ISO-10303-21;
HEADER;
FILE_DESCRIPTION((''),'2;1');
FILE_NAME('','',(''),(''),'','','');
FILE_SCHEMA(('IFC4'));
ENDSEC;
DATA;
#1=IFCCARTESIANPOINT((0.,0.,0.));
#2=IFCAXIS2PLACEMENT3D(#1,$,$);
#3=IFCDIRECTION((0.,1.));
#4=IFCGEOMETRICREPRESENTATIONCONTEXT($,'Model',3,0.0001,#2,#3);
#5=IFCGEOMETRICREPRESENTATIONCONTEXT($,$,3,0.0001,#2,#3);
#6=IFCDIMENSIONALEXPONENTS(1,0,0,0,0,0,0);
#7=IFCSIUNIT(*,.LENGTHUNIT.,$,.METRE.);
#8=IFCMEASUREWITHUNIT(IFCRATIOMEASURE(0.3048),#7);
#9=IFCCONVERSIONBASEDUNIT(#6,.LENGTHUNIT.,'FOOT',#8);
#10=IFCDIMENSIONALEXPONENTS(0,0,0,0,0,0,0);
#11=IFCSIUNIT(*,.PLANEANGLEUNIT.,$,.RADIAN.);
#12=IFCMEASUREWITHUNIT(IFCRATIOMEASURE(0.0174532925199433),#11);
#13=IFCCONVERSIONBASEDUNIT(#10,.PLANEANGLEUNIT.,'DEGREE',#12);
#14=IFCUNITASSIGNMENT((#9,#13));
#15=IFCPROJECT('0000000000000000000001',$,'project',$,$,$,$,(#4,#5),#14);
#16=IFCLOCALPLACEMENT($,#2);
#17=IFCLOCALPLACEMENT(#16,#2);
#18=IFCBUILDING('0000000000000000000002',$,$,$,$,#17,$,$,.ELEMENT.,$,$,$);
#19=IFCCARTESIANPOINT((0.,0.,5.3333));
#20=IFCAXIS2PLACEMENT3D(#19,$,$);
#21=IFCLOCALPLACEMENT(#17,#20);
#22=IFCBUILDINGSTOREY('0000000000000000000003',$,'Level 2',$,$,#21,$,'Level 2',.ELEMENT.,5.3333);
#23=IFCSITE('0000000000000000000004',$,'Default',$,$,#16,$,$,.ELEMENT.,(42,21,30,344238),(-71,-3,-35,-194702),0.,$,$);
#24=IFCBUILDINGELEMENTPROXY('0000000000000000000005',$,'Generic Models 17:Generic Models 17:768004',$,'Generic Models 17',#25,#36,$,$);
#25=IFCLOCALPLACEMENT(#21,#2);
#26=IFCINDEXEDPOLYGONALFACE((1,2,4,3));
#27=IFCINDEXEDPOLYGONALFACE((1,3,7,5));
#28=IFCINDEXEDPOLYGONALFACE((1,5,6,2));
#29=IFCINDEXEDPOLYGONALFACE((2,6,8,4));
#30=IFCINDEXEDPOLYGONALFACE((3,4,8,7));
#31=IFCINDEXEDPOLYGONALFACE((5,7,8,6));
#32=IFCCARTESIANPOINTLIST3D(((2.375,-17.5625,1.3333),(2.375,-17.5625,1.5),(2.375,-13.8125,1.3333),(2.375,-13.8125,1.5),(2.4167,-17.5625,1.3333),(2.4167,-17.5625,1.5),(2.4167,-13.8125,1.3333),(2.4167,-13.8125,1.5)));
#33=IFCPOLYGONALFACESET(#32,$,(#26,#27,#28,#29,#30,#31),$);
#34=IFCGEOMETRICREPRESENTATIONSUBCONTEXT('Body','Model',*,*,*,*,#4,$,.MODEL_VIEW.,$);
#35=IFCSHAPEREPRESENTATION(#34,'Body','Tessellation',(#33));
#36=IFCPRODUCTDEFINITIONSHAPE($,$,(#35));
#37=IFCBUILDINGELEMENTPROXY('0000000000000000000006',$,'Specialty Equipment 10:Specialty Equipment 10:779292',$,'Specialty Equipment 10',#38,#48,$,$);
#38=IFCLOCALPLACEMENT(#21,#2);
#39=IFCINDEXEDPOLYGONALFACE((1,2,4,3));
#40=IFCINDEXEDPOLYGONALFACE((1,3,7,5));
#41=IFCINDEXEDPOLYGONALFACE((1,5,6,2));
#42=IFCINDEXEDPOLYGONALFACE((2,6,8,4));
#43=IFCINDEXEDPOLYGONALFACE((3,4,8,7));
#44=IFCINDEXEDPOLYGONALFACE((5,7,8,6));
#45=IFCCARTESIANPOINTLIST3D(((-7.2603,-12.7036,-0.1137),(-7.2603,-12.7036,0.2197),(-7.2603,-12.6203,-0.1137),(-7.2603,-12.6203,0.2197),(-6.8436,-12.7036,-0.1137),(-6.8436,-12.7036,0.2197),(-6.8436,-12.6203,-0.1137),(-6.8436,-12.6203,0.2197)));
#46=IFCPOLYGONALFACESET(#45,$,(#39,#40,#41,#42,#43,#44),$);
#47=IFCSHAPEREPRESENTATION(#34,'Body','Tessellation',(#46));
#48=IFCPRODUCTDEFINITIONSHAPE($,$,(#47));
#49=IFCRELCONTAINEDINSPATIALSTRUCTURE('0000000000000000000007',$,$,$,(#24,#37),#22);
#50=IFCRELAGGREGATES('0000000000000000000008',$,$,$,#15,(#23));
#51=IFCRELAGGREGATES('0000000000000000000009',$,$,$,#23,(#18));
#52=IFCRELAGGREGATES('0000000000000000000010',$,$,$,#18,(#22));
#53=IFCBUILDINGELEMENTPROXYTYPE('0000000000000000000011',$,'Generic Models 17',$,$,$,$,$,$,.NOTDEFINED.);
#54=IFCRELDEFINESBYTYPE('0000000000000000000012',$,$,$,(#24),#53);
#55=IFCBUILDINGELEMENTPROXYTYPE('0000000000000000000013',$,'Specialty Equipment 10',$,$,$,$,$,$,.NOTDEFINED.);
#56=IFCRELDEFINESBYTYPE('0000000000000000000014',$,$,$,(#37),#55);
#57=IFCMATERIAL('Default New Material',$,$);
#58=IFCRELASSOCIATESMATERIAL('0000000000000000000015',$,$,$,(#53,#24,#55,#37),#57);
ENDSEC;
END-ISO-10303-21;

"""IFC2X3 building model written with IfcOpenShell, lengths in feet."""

from ifc_helpers import new_model, entity, si_unit, converted_unit, direction, frame, frame_2d, origin, origin_2d_with_axis, place, context, subcontext, project, spatial, rectangle, extrude, source, transform, mapped, material, type_object, type_shapes, element, save


model = new_model("IFC2X3")

# Units and contexts
model_context = context("Model", 3, precision=0.0001, world=origin(), true_north=direction((0.0, 1.0)))
context_of_model = context(None, 3, precision=0.0001, world=origin(), true_north=direction((0.0, 1.0)))
body_context = subcontext(model_context, "Body", "Model", "MODEL_VIEW")
ifc_project = project(units=[converted_unit("LENGTHUNIT", "FOOT", entity("IfcRatioMeasure", 0.3048), si_unit("LENGTHUNIT", "METRE"), dimensions=[1, 0, 0, 0, 0, 0, 0]), converted_unit("PLANEANGLEUNIT", "DEGREE", entity("IfcRatioMeasure", 0.0174532925199433), si_unit("PLANEANGLEUNIT", "RADIAN"), dimensions=[0, 0, 0, 0, 0, 0, 0])], contexts=[model_context, context_of_model])

# Site, building, storey
site_placement = place(None, origin())
site = spatial("IfcSite", under=ifc_project, at=site_placement, Name="Default", CompositionType="ELEMENT", RefLatitude=(42, 21, 30, 344238), RefLongitude=(-71, -3, -35, -194702), RefElevation=0.0)
building_placement = place(site_placement, origin())
building = spatial("IfcBuilding", under=site, at=building_placement, CompositionType="ELEMENT")
storey_placement = place(building_placement, frame((0.0, 0.0, 5.3333)))
storey = spatial("IfcBuildingStorey", under=building, at=storey_placement, Name="Level 2", LongName="Level 2", CompositionType="ELEMENT", Elevation=5.3333)

# Shared definitions
ifc_material_1 = material(Name="Default New Material")

# Building element proxies
building_element_proxy_type_1 = type_object("IfcBuildingElementProxyType", Name="Generic Models 17", PredefinedType="NOTDEFINED", material=ifc_material_1)
shared_shape_1 = source(origin(), body_context, "Body", "SweptSolid", [
    extrude(rectangle(XDim=0.0417, YDim=3.75, at=origin_2d_with_axis()), frame((0.0208, 1.875, 0.0)), (0.0, 0.0, 1.0), 0.1667),
])
type_shapes(building_element_proxy_type_1, [shared_shape_1])
proxy_1_placement = place(storey_placement, frame((2.375, -17.5625, 1.3333)))
element("IfcBuildingElementProxy", 1, at=proxy_1_placement, inside=storey, type_object=building_element_proxy_type_1, material=ifc_material_1, Name="Generic Models 17:Generic Models 17:768004", ObjectType="Generic Models 17", context=body_context, shape_type="MappedRepresentation", body=[
    mapped(shared_shape_1, transform((0.0, 0.0, 0.0), scale=1.0)),
])
building_element_proxy_type_2 = type_object("IfcBuildingElementProxyType", Name="Specialty Equipment 10", PredefinedType="NOTDEFINED", material=ifc_material_1)
shared_shape_2 = source(origin(), body_context, "Body", "SweptSolid", [
    extrude(rectangle(XDim=0.0833, YDim=0.4167, at=frame_2d((0.0, 0.0), x_axis=(1.0, 0.0))), frame((0.2083, 0.0417, 0.0), z_axis=(0.0, 0.0, 1.0), x_axis=(0.0, 1.0, 0.0)), (0.0, 0.0, 1.0), 0.3333),
])
type_shapes(building_element_proxy_type_2, [shared_shape_2])
proxy_2_placement = place(storey_placement, frame((-7.2603, -12.7036, -0.1137)))
element("IfcBuildingElementProxy", 2, at=proxy_2_placement, inside=storey, type_object=building_element_proxy_type_2, material=ifc_material_1, Name="Specialty Equipment 10:Specialty Equipment 10:779292", ObjectType="Specialty Equipment 10", context=body_context, shape_type="MappedRepresentation", body=[
    mapped(shared_shape_2, transform((0.0, 0.0, 0.0), scale=1.0)),
])

save(model, "model.ifc")
